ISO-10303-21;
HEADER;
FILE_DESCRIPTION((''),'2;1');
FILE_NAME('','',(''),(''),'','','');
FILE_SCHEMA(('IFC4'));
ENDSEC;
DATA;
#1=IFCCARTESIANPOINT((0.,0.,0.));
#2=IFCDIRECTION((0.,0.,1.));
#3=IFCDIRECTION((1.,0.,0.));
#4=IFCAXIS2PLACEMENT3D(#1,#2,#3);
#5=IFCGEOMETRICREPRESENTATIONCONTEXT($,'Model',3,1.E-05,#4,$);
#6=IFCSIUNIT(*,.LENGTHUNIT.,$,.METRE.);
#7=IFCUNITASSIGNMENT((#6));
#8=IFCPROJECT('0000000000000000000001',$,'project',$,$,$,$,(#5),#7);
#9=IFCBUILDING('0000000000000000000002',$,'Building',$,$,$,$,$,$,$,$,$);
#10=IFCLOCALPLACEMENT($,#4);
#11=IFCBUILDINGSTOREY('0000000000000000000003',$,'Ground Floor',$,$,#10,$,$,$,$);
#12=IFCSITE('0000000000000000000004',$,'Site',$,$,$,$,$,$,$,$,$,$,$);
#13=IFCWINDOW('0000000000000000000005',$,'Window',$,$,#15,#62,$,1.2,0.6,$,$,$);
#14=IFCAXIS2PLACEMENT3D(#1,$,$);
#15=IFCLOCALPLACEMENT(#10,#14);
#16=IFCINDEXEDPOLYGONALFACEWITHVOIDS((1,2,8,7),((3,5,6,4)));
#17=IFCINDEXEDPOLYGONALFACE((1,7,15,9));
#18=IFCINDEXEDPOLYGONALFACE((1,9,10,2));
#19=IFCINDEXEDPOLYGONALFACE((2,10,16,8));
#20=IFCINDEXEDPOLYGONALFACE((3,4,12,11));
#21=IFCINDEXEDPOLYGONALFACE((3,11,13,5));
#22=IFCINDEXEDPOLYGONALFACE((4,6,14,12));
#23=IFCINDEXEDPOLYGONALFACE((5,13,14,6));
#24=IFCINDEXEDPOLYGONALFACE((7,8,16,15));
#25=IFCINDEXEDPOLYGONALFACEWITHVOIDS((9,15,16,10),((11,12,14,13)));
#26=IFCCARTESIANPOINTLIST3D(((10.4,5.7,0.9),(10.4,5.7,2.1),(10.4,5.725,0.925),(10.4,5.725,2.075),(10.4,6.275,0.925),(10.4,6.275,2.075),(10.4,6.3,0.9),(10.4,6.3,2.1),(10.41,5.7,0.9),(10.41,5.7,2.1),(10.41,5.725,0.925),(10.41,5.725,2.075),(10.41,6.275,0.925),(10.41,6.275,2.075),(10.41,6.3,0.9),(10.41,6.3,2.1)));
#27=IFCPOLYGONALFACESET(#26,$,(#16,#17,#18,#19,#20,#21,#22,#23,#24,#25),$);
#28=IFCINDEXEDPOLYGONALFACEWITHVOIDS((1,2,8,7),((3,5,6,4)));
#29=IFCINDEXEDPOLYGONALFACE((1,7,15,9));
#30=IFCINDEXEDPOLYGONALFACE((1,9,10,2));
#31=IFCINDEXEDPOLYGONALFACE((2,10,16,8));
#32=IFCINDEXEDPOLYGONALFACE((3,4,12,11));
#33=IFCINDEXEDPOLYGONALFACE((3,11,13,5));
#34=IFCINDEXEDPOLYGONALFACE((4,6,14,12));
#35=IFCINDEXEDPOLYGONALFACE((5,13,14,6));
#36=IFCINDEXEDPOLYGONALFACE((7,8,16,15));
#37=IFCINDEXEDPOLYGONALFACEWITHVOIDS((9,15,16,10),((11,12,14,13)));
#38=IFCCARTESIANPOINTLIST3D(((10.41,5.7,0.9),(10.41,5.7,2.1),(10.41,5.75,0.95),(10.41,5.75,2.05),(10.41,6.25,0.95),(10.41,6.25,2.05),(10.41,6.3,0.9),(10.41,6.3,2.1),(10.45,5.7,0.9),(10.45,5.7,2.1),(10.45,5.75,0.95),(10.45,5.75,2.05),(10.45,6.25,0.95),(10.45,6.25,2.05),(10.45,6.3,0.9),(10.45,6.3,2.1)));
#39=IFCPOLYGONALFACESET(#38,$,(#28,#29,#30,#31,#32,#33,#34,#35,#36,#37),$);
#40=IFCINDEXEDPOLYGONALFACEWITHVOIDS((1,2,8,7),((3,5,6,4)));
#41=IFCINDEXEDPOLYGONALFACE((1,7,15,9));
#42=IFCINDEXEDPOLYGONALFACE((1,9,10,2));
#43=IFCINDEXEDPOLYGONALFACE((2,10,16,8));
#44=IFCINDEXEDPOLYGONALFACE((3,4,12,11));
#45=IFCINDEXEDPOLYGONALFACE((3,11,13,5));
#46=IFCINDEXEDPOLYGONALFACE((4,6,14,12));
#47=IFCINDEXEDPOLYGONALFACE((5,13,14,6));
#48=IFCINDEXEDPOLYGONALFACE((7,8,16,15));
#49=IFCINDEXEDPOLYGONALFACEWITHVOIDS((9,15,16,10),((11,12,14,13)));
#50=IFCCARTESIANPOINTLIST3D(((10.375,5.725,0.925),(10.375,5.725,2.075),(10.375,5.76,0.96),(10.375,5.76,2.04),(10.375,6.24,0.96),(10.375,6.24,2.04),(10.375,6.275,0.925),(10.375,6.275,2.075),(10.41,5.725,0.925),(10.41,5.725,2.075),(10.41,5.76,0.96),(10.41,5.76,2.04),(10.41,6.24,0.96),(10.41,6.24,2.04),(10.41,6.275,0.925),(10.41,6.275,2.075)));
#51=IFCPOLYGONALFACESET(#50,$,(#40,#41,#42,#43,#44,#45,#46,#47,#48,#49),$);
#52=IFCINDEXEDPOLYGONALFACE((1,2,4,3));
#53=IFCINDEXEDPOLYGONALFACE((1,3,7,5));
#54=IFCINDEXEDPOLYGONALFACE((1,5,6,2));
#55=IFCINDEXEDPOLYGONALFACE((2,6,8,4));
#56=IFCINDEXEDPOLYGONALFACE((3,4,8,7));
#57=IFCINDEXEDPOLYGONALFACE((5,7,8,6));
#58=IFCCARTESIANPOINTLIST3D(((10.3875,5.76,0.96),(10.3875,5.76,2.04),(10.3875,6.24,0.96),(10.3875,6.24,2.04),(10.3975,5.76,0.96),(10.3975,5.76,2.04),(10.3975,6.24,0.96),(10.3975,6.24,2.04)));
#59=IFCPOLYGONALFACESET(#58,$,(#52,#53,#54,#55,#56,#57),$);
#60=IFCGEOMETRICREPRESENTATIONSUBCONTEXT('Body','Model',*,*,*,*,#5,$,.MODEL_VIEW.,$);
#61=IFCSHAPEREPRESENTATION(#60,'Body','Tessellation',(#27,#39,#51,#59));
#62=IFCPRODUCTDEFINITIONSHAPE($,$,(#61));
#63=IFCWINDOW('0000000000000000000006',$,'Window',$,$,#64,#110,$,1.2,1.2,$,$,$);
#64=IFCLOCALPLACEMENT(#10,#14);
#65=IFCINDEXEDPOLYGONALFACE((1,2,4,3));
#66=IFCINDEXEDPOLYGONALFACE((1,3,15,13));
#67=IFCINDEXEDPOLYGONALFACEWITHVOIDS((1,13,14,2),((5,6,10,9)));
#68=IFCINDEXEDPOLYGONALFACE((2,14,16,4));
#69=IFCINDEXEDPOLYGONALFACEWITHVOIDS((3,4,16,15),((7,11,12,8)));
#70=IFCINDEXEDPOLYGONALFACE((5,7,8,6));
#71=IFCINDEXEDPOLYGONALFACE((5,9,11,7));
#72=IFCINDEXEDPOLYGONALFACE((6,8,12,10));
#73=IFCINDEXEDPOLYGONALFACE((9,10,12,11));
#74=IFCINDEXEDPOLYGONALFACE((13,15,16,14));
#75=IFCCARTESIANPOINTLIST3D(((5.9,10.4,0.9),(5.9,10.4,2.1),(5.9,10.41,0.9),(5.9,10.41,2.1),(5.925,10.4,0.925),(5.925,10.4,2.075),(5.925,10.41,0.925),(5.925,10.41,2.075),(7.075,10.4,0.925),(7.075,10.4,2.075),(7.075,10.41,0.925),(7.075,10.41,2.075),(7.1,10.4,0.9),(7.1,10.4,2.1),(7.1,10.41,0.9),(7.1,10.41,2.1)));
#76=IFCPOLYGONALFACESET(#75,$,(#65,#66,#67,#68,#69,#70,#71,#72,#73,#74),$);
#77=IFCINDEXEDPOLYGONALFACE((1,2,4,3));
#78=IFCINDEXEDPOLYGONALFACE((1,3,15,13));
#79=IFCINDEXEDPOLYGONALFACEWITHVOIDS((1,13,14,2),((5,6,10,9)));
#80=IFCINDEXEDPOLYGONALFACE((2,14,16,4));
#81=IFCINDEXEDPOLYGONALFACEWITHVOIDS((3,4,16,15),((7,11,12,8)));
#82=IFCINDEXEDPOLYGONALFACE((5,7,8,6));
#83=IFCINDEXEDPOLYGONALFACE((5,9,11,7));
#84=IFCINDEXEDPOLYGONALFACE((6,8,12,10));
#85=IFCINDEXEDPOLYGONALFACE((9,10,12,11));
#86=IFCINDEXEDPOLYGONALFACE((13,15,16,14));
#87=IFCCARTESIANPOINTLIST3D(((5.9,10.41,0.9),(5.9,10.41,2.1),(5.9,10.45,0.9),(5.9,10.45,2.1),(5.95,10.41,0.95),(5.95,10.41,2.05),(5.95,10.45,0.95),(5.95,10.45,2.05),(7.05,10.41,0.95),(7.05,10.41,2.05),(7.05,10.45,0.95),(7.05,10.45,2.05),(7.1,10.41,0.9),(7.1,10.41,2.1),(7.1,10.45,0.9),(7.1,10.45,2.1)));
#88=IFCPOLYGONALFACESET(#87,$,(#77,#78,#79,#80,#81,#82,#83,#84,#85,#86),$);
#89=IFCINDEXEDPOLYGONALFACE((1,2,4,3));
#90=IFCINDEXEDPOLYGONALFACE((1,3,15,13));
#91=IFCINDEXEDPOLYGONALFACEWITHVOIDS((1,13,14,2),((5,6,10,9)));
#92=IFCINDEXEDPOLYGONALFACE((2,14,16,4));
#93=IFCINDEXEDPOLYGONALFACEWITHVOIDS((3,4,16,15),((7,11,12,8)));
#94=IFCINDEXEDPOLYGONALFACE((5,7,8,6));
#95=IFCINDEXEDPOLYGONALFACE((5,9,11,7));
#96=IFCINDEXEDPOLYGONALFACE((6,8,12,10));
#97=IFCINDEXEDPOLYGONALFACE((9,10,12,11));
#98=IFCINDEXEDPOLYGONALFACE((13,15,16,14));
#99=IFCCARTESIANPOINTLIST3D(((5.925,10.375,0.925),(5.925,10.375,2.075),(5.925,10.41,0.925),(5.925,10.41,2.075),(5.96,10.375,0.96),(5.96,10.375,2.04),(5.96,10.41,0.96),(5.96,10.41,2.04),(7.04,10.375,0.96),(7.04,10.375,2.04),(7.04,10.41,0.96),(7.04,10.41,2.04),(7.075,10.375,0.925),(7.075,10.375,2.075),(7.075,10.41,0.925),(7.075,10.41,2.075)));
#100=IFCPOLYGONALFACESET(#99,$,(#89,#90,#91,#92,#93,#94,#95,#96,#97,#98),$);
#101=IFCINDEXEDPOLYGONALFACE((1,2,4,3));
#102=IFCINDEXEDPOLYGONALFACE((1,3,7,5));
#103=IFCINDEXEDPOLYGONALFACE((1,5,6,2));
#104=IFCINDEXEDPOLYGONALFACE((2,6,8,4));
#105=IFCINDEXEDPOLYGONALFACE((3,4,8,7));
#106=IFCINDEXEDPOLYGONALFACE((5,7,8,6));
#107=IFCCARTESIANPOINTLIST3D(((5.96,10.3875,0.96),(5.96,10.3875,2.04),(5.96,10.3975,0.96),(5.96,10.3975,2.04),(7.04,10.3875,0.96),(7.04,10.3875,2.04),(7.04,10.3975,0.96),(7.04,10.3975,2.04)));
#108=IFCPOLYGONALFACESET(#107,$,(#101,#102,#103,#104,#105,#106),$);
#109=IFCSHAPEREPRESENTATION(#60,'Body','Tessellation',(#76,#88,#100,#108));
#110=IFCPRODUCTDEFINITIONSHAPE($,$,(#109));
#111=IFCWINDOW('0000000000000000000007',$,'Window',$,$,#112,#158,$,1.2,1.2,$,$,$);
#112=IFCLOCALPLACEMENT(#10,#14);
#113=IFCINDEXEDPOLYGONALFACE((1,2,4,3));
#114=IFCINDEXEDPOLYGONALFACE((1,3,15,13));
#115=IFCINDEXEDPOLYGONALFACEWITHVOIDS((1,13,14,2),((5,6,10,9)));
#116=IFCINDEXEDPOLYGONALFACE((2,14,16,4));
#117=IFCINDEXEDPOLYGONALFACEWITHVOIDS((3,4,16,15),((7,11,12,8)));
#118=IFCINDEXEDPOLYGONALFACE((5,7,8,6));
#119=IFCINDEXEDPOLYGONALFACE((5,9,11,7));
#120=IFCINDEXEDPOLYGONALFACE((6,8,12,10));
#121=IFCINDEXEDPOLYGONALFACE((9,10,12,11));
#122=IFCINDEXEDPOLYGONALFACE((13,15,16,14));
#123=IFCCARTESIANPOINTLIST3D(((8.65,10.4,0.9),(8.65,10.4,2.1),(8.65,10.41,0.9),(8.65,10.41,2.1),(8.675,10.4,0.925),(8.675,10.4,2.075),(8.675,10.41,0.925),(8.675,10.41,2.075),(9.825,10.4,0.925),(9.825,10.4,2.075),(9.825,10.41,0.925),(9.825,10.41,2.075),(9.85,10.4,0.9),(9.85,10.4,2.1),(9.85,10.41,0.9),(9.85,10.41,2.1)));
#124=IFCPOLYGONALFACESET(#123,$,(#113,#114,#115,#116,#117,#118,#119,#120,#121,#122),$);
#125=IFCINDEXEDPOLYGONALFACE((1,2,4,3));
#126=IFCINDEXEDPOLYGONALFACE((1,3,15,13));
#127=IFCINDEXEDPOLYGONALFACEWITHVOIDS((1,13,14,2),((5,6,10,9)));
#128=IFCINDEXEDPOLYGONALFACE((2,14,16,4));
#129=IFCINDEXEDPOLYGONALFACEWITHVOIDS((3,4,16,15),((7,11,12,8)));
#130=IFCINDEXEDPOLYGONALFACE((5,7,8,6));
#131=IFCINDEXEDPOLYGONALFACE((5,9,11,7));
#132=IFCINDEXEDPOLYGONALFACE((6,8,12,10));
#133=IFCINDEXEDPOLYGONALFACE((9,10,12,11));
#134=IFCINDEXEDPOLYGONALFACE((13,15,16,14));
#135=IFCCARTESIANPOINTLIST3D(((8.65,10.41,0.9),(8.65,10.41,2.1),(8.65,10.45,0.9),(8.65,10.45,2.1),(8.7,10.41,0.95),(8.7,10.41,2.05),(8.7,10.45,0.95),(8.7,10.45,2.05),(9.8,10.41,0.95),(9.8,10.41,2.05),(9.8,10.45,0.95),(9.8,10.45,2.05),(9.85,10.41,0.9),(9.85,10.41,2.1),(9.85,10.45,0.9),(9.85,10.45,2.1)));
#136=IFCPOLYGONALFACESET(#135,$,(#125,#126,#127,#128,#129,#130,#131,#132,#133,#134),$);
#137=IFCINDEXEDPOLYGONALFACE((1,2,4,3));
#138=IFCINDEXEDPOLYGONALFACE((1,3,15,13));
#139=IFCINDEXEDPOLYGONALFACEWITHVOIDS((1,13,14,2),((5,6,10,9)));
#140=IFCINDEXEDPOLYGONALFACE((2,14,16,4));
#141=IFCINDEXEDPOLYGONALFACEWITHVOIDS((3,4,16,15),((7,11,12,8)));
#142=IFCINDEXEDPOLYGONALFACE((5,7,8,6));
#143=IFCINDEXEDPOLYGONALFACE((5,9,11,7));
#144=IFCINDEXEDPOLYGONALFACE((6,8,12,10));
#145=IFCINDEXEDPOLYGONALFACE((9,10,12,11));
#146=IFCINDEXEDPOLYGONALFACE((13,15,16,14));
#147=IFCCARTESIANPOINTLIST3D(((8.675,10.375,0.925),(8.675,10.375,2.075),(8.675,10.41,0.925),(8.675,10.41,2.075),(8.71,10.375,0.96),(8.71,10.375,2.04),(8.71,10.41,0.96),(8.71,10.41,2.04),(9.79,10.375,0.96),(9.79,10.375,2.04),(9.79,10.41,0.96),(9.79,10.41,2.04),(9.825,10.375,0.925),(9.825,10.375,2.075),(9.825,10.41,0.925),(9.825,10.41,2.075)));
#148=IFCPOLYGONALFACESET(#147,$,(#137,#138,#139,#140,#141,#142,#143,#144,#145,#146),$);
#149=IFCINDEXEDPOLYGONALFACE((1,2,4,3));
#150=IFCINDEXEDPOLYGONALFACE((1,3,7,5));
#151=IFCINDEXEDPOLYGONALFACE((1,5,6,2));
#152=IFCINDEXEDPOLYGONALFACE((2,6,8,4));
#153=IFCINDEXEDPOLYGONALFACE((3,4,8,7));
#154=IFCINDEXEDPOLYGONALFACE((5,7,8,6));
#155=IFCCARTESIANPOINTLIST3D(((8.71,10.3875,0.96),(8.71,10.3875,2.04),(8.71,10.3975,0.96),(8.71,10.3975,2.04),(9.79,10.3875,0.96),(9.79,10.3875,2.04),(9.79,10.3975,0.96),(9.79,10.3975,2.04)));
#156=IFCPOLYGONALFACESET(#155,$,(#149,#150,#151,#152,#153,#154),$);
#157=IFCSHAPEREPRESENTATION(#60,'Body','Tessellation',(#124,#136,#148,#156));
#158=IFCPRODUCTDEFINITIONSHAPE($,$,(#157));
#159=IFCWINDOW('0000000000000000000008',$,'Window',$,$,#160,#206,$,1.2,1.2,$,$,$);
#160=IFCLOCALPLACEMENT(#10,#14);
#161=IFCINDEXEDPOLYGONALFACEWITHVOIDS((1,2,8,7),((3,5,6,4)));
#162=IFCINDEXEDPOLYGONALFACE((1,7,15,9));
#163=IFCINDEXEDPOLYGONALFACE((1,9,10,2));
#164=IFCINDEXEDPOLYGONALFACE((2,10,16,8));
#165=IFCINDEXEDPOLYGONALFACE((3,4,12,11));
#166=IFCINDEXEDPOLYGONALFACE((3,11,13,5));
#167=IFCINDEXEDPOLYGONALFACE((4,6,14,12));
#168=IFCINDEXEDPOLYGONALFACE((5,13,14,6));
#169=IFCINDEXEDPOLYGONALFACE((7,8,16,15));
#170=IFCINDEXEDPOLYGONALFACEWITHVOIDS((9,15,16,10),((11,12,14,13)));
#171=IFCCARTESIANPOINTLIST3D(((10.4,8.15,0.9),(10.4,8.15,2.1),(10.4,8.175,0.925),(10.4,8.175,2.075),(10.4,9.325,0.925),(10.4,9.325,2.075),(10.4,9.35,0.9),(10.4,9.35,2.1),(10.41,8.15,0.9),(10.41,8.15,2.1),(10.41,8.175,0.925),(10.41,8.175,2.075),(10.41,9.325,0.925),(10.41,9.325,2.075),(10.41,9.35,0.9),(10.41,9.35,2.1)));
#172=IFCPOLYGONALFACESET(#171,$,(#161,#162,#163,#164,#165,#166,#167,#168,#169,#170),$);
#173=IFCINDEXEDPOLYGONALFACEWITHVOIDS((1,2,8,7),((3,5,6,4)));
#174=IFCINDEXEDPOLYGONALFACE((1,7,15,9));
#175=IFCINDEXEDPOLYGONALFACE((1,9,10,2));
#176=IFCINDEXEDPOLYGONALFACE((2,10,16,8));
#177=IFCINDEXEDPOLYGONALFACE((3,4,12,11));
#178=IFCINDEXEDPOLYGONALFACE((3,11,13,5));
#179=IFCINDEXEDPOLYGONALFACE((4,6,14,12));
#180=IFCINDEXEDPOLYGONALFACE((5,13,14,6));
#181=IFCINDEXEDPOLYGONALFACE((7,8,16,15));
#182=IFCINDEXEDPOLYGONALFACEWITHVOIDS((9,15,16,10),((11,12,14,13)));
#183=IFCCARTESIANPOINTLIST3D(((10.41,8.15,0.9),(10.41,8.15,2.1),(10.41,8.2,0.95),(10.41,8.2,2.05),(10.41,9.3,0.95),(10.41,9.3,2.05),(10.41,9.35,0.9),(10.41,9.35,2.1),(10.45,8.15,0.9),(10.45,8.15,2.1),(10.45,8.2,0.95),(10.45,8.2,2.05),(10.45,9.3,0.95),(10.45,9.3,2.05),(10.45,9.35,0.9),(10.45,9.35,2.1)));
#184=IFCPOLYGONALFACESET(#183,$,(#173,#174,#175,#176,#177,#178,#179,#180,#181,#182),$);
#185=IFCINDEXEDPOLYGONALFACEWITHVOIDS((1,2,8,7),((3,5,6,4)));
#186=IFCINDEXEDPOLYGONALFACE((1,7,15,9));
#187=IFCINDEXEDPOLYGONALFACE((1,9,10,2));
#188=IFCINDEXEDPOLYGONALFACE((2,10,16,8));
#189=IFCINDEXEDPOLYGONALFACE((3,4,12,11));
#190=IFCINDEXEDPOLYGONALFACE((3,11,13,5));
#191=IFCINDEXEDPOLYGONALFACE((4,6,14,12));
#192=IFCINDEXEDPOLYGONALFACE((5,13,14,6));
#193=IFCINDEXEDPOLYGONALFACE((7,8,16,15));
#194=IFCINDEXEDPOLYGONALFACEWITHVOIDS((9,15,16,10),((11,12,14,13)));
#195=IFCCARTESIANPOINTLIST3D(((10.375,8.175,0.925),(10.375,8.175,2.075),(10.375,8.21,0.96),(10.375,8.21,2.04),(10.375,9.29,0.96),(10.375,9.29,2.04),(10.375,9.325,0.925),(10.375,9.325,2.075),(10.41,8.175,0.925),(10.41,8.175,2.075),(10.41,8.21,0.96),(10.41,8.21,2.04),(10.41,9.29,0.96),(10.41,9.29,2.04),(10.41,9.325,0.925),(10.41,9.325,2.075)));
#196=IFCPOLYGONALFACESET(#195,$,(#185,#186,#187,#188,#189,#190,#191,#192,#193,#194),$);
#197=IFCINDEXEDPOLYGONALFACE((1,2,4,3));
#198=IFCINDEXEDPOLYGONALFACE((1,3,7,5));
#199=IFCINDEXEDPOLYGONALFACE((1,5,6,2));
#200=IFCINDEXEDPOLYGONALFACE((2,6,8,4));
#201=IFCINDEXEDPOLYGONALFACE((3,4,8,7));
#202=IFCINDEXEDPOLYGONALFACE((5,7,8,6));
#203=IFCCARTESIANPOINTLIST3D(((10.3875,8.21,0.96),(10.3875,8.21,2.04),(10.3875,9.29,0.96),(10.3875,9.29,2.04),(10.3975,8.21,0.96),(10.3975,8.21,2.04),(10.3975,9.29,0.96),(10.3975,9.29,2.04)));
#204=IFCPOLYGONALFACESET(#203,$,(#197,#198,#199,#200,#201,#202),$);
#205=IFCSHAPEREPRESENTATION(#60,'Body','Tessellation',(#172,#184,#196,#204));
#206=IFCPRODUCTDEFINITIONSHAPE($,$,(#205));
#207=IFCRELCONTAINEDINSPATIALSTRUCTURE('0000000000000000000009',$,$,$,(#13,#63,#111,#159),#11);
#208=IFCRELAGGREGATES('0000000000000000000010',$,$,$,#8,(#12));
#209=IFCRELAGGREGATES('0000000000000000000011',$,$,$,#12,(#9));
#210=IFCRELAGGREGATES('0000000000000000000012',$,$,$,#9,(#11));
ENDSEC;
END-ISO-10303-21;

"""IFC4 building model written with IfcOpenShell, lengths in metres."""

from ifc_helpers import new_model, si_unit, frame, origin_with_axes, place, context, subcontext, project, spatial, line, indexed_curve, outline, extrude, element, save


model = new_model("IFC4")

# Units and contexts
model_context = context("Model", 3, precision=1e-05, world=origin_with_axes())
body_context = subcontext(model_context, "Body", "Model", "MODEL_VIEW")
ifc_project = project(units=[si_unit("LENGTHUNIT", "METRE")], contexts=[model_context])

# Site, building, storey
site = spatial("IfcSite", under=ifc_project, Name="Site")
building = spatial("IfcBuilding", under=site, Name="Building")
storey_placement = place(None, origin_with_axes())
storey = spatial("IfcBuildingStorey", under=building, at=storey_placement, Name="Ground Floor")

# Windows
window_1_placement = place(storey_placement, frame((10.5, 5.7, 0.9), z_axis=(0.0, 0.0, 1.0), x_axis=(0.0, 1.0, 0.0)))
element("IfcWindow", 1, at=window_1_placement, inside=storey, Name="Window", OverallHeight=1.2, OverallWidth=0.6, context=body_context, shape_type="SweptSolid", body=[
    extrude(outline(indexed_curve([(0.0, 0.0), (0.6, 0.0), (0.6, 1.2), (0.0, 1.2)], segments=[line(1, 2, 3, 4, 1)]), holes=[indexed_curve([(0.025, 0.025), (0.575, 0.025), (0.575, 1.175), (0.025, 1.175)], segments=[line(1, 2, 3, 4, 1)])]), frame((0.0, 0.09, 0.0), z_axis=(0.0, -1.0, 0.0), x_axis=(1.0, 0.0, 0.0)), (0.0, 0.0, -1.0), 0.01),
    extrude(outline(indexed_curve([(0.0, 0.0), (0.6, 0.0), (0.6, 1.2), (0.0, 1.2)], segments=[line(1, 2, 3, 4, 1)]), holes=[indexed_curve([(0.05, 0.05), (0.55, 0.05), (0.55, 1.15), (0.05, 1.15)], segments=[line(1, 2, 3, 4, 1)])]), frame((0.0, 0.05, 0.0), z_axis=(0.0, -1.0, 0.0), x_axis=(1.0, 0.0, 0.0)), (0.0, 0.0, -1.0), 0.04),
    extrude(outline(indexed_curve([(0.0, 0.0), (0.55, 0.0), (0.55, 1.15), (0.0, 1.15)], segments=[line(1, 2, 3, 4, 1)]), holes=[indexed_curve([(0.035, 0.035), (0.515, 0.035), (0.515, 1.115), (0.035, 1.115)], segments=[line(1, 2, 3, 4, 1)])]), frame((0.025, 0.09, 0.025), z_axis=(0.0, -1.0, 0.0), x_axis=(1.0, 0.0, 0.0)), (0.0, 0.0, -1.0), 0.035),
    extrude(outline(indexed_curve([(0.035, 0.035), (0.515, 0.035), (0.515, 1.115), (0.035, 1.115)], segments=[line(1, 2, 3, 4, 1)])), frame((0.025, 0.1025, 0.025), z_axis=(0.0, -1.0, 0.0), x_axis=(1.0, 0.0, 0.0)), (0.0, 0.0, -1.0), 0.01),
])
for number, where, z_axis, x_axis, name in (
    (2, (7.1, 10.5, 0.9), (0.0, 0.0, 1.0), (-1.0, 0.0, 0.0), "Window"),
    (3, (9.85, 10.5, 0.9), (0.0, 0.0, 1.0), (-1.0, 0.0, 0.0), "Window"),
    (4, (10.5, 8.15, 0.9), (0.0, 0.0, 1.0), (0.0, 1.0, 0.0), "Window"),
):
    element("IfcWindow", number, at=place(storey_placement, frame(where, z_axis=z_axis, x_axis=x_axis)), inside=storey, Name=name, OverallHeight=1.2, OverallWidth=1.2, context=body_context, shape_type="SweptSolid", body=[
        extrude(outline(indexed_curve([(0.0, 0.0), (1.2, 0.0), (1.2, 1.2), (0.0, 1.2)], segments=[line(1, 2, 3, 4, 1)]), holes=[indexed_curve([(0.025, 0.025), (1.175, 0.025), (1.175, 1.175), (0.025, 1.175)], segments=[line(1, 2, 3, 4, 1)])]), frame((0.0, 0.09, 0.0), z_axis=(0.0, -1.0, 0.0), x_axis=(1.0, 0.0, 0.0)), (0.0, 0.0, -1.0), 0.01),
        extrude(outline(indexed_curve([(0.0, 0.0), (1.2, 0.0), (1.2, 1.2), (0.0, 1.2)], segments=[line(1, 2, 3, 4, 1)]), holes=[indexed_curve([(0.05, 0.05), (1.15, 0.05), (1.15, 1.15), (0.05, 1.15)], segments=[line(1, 2, 3, 4, 1)])]), frame((0.0, 0.05, 0.0), z_axis=(0.0, -1.0, 0.0), x_axis=(1.0, 0.0, 0.0)), (0.0, 0.0, -1.0), 0.04),
        extrude(outline(indexed_curve([(0.0, 0.0), (1.15, 0.0), (1.15, 1.15), (0.0, 1.15)], segments=[line(1, 2, 3, 4, 1)]), holes=[indexed_curve([(0.035, 0.035), (1.115, 0.035), (1.115, 1.115), (0.035, 1.115)], segments=[line(1, 2, 3, 4, 1)])]), frame((0.025, 0.09, 0.025), z_axis=(0.0, -1.0, 0.0), x_axis=(1.0, 0.0, 0.0)), (0.0, 0.0, -1.0), 0.035),
        extrude(outline(indexed_curve([(0.035, 0.035), (1.115, 0.035), (1.115, 1.115), (0.035, 1.115)], segments=[line(1, 2, 3, 4, 1)])), frame((0.025, 0.1025, 0.025), z_axis=(0.0, -1.0, 0.0), x_axis=(1.0, 0.0, 0.0)), (0.0, 0.0, -1.0), 0.01),
    ])

save(model, "model.ifc")
